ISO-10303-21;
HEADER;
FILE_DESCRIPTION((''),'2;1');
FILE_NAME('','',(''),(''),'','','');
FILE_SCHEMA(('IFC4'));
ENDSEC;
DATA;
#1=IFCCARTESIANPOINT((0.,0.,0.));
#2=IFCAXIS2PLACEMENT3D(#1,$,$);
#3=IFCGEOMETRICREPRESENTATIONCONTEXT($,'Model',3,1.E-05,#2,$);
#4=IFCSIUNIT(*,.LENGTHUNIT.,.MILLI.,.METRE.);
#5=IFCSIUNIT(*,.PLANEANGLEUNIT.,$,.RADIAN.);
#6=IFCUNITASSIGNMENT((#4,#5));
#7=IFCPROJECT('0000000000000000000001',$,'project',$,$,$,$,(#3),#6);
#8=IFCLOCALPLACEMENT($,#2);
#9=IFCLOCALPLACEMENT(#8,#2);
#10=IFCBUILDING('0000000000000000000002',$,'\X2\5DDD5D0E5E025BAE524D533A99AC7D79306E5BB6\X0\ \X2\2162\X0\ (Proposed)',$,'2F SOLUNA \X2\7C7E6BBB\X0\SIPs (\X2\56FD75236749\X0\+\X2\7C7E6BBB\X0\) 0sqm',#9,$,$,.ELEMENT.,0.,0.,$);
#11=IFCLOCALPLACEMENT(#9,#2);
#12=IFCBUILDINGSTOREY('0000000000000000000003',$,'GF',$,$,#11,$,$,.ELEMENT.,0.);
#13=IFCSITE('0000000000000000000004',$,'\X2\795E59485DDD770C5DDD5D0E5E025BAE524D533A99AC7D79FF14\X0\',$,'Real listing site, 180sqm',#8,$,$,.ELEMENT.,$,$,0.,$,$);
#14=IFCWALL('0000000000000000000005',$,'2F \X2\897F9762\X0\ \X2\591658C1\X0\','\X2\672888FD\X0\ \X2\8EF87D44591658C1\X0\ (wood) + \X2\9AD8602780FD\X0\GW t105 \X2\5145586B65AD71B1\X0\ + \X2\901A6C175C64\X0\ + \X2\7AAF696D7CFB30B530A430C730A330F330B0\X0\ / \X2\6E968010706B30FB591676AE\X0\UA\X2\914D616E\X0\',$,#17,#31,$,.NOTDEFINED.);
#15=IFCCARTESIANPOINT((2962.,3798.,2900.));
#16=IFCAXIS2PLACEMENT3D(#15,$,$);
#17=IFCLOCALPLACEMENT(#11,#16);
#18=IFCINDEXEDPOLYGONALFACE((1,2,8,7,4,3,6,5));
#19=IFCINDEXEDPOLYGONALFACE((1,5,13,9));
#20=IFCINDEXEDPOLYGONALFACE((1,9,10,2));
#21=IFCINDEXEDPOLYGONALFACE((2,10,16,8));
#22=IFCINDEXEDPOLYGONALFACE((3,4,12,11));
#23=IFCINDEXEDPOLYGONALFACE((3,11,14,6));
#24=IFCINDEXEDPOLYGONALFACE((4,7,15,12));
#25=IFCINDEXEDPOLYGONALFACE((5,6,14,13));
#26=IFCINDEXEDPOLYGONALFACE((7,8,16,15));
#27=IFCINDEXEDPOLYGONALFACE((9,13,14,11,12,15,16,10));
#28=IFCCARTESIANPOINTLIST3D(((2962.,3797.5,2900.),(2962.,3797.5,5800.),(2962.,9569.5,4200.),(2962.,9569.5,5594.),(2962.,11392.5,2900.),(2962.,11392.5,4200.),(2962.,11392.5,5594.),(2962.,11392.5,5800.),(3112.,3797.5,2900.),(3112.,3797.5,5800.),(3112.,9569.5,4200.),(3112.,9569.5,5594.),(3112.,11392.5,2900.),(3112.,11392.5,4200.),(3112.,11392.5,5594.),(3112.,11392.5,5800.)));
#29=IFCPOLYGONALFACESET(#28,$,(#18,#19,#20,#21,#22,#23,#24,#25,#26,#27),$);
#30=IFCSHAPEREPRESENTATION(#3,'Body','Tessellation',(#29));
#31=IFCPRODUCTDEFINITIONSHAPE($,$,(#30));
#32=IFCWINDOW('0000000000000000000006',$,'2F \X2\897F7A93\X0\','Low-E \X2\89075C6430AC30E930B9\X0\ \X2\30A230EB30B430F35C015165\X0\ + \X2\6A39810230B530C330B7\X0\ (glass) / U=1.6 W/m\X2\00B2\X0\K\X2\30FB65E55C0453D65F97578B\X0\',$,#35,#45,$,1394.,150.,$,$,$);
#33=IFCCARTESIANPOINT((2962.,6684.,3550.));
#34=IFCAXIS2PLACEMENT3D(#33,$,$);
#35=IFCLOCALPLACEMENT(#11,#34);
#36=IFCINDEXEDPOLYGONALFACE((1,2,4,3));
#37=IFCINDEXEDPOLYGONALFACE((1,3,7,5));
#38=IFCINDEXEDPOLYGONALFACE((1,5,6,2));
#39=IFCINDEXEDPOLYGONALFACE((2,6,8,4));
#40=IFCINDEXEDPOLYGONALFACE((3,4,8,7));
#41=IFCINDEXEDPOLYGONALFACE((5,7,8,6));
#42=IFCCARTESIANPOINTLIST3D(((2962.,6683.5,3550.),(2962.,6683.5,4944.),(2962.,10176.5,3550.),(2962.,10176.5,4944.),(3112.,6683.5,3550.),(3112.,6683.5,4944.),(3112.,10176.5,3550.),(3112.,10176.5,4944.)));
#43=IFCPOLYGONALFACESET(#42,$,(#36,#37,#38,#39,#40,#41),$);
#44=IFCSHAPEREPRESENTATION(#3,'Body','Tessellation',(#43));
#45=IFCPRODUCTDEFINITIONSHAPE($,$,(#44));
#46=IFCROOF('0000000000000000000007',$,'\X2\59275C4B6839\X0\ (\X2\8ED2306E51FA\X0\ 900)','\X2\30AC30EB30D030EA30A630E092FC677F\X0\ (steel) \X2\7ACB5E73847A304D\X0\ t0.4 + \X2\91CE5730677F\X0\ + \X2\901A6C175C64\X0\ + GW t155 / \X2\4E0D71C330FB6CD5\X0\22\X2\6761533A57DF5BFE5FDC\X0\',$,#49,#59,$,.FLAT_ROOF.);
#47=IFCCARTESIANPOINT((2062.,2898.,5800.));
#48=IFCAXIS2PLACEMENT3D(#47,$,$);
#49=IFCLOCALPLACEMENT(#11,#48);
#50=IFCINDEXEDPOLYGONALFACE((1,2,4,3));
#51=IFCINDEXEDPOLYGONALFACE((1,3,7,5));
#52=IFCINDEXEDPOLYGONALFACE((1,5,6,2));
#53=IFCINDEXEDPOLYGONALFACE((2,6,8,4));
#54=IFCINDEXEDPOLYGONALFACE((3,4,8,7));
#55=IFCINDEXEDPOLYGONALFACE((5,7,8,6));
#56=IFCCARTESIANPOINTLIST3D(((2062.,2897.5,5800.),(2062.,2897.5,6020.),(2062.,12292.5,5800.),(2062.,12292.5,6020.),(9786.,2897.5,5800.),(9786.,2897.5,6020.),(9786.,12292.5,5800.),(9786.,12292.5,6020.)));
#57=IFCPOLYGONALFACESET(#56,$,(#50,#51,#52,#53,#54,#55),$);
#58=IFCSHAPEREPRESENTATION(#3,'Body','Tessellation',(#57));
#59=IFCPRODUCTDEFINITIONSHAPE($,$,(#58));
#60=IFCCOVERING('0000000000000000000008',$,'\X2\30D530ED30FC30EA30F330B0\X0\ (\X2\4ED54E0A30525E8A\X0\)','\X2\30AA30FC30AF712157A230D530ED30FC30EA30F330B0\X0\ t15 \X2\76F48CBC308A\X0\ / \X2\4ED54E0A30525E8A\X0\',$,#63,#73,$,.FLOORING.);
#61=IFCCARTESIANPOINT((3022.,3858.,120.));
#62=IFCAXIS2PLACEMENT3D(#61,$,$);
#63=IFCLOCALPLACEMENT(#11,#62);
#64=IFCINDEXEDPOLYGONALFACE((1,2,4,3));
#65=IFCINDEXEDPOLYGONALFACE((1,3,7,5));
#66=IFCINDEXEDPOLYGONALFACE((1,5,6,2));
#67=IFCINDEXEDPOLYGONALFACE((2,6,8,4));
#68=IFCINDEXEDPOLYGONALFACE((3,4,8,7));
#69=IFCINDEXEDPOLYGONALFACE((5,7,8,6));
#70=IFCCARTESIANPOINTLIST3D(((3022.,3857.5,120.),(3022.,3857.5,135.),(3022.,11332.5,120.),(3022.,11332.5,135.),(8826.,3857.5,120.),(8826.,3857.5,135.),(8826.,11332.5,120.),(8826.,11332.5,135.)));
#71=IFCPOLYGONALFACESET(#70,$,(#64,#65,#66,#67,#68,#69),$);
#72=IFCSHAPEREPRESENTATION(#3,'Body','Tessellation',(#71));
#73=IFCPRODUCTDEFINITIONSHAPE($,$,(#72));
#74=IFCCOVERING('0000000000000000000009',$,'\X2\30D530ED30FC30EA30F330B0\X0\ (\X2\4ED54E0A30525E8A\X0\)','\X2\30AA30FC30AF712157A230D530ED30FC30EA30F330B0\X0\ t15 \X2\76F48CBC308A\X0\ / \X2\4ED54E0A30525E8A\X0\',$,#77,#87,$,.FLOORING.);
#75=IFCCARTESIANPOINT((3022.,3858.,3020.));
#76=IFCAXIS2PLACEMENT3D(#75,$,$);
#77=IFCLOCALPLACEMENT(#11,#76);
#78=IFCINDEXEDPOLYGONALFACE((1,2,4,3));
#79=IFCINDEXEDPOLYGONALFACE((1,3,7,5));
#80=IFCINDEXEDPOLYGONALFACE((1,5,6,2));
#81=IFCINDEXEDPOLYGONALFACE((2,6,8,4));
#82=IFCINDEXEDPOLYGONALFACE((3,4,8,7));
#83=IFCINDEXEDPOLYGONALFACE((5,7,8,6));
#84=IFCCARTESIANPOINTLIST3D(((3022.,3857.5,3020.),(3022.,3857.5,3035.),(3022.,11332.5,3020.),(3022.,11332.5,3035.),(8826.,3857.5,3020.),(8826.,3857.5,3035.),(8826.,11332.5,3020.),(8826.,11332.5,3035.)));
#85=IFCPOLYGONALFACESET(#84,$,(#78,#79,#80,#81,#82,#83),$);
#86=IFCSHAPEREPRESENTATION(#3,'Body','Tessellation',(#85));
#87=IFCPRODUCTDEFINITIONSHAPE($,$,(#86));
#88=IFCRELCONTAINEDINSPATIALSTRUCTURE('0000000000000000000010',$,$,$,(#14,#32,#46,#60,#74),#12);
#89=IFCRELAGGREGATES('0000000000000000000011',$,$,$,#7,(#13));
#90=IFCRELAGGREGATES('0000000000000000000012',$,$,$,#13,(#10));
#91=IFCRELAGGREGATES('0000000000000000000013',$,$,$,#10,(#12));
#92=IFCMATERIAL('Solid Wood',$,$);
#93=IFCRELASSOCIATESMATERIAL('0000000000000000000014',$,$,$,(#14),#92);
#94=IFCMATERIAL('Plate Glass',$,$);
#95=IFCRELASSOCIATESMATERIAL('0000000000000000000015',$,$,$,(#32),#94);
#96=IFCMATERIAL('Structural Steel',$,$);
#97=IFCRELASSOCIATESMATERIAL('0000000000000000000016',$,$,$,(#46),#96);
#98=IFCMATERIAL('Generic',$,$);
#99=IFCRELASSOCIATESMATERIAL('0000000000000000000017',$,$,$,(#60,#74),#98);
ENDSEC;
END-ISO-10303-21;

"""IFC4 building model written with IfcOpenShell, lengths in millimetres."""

from ifc_helpers import new_model, si_unit, frame, frame_2d, origin, place, context, project, spatial, rectangle, extrude, material, element, fill, save


model = new_model("IFC4")

# Units and contexts
model_context = context("Model", 3, precision=1e-05, world=origin())
ifc_project = project(units=[si_unit("LENGTHUNIT", "METRE", prefix="MILLI"), si_unit("PLANEANGLEUNIT", "RADIAN")], contexts=[model_context])

# Site, building, storey
site_placement = place(None, origin())
site = spatial("IfcSite", under=ifc_project, at=site_placement, Name="神奈川県川崎市宮前区馬絹４", ObjectType="Real listing site, 180sqm", CompositionType="ELEMENT", RefElevation=0.0)
building_placement = place(site_placement, origin())
building = spatial("IfcBuilding", under=site, at=building_placement, Name="川崎市宮前区馬絹の家 Ⅲ (Proposed)", ObjectType="2F SOLUNA 籾殻SIPs (国産杉+籾殻) 0sqm", CompositionType="ELEMENT", ElevationOfRefHeight=0.0, ElevationOfTerrain=0.0)
storey_placement = place(building_placement, origin())
storey = spatial("IfcBuildingStorey", under=building, at=storey_placement, Name="GF", CompositionType="ELEMENT", Elevation=0.0)

# Shared definitions
ifc_material_1 = material(Name="Solid Wood")

# Shared definitions
ifc_material_2 = material(Name="Plate Glass")

# Wall, opening, window
wall_1_placement = place(storey_placement, frame((2962.0, 3798.0, 2900.0)))
wall_1 = element("IfcWall", 1, at=wall_1_placement, inside=storey, material=ifc_material_1, Name="2F 西面 外壁", Description="木製 軸組外壁 (wood) + 高性能GW t105 充填断熱 + 通気層 + 窯業系サイディング / 準耐火・外皮UA配慮", PredefinedType="NOTDEFINED", context=model_context, shape_type="SweptSolid", body=[
    extrude(rectangle(XDim=150.0, YDim=7595.0, at=frame_2d((75.0, 3797.0))), frame((2962.0, 3798.0, 2900.0)), (0.0, 0.0, 1.0), 2900.0),
])
opening_1_placement = place(storey_placement, frame((2962.0, 6684.0, 3550.0)))
opening_1 = element("IfcOpeningElement", 2, at=opening_1_placement, cuts=wall_1, PredefinedType="NOTDEFINED", context=model_context, shape_type="SweptSolid", body=[
    extrude(rectangle(XDim=150.0, YDim=3493.0, at=frame_2d((75.0, 1746.0))), frame((2962.0, 6684.0, 3550.0)), (0.0, 0.0, 1.0), 1394.0),
])
window_1_placement = place(storey_placement, frame((2962.0, 6684.0, 3550.0)))
window_1 = element("IfcWindow", 3, at=window_1_placement, inside=storey, material=ifc_material_2, Name="2F 西窓", Description="Low-E 複層ガラス アルゴン封入 + 樹脂サッシ (glass) / U=1.6 W/m²K・日射取得型", OverallHeight=1394.0, OverallWidth=150.0, context=model_context, shape_type="SweptSolid", body=[
    extrude(rectangle(XDim=150.0, YDim=3493.0, at=frame_2d((75.0, 1746.0))), frame((2962.0, 6684.0, 3550.0)), (0.0, 0.0, 1.0), 1394.0),
])
fill(opening_1, window_1)

# Roof
ifc_material_3 = material(Name="Structural Steel")
roof_placement = place(storey_placement, frame((2062.0, 2898.0, 5800.0)))
element("IfcRoof", 4, at=roof_placement, inside=storey, material=ifc_material_3, Name="大屋根 (軒の出 900)", Description="ガルバリウム鋼板 (steel) 立平葺き t0.4 + 野地板 + 通気層 + GW t155 / 不燃・法22条区域対応", PredefinedType="FLAT_ROOF", context=model_context, shape_type="SweptSolid", body=[
    extrude(rectangle(XDim=7724.0, YDim=9395.0, at=frame_2d((3862.0, 4697.0))), frame((2062.0, 2898.0, 5800.0)), (0.0, 0.0, 1.0), 220.0),
])

# Coverings
ifc_material_4 = material(Name="Generic")
covering_1_placement = place(storey_placement, frame((3022.0, 3858.0, 120.0)))
element("IfcCovering", 5, at=covering_1_placement, inside=storey, material=ifc_material_4, Name="フローリング (仕上げ床)", Description="オーク無垢フローリング t15 直貼り / 仕上げ床", PredefinedType="FLOORING", context=model_context, shape_type="SweptSolid", body=[
    extrude(rectangle(XDim=5804.0, YDim=7475.0, at=frame_2d((2902.0, 3737.0))), frame((3022.0, 3858.0, 120.0)), (0.0, 0.0, 1.0), 15.0),
])
covering_2_placement = place(storey_placement, frame((3022.0, 3858.0, 3020.0)))
element("IfcCovering", 6, at=covering_2_placement, inside=storey, material=ifc_material_4, Name="フローリング (仕上げ床)", Description="オーク無垢フローリング t15 直貼り / 仕上げ床", PredefinedType="FLOORING", context=model_context, shape_type="SweptSolid", body=[
    extrude(rectangle(XDim=5804.0, YDim=7475.0, at=frame_2d((2902.0, 3737.0))), frame((3022.0, 3858.0, 3020.0)), (0.0, 0.0, 1.0), 15.0),
])

save(model, "model.ifc")
